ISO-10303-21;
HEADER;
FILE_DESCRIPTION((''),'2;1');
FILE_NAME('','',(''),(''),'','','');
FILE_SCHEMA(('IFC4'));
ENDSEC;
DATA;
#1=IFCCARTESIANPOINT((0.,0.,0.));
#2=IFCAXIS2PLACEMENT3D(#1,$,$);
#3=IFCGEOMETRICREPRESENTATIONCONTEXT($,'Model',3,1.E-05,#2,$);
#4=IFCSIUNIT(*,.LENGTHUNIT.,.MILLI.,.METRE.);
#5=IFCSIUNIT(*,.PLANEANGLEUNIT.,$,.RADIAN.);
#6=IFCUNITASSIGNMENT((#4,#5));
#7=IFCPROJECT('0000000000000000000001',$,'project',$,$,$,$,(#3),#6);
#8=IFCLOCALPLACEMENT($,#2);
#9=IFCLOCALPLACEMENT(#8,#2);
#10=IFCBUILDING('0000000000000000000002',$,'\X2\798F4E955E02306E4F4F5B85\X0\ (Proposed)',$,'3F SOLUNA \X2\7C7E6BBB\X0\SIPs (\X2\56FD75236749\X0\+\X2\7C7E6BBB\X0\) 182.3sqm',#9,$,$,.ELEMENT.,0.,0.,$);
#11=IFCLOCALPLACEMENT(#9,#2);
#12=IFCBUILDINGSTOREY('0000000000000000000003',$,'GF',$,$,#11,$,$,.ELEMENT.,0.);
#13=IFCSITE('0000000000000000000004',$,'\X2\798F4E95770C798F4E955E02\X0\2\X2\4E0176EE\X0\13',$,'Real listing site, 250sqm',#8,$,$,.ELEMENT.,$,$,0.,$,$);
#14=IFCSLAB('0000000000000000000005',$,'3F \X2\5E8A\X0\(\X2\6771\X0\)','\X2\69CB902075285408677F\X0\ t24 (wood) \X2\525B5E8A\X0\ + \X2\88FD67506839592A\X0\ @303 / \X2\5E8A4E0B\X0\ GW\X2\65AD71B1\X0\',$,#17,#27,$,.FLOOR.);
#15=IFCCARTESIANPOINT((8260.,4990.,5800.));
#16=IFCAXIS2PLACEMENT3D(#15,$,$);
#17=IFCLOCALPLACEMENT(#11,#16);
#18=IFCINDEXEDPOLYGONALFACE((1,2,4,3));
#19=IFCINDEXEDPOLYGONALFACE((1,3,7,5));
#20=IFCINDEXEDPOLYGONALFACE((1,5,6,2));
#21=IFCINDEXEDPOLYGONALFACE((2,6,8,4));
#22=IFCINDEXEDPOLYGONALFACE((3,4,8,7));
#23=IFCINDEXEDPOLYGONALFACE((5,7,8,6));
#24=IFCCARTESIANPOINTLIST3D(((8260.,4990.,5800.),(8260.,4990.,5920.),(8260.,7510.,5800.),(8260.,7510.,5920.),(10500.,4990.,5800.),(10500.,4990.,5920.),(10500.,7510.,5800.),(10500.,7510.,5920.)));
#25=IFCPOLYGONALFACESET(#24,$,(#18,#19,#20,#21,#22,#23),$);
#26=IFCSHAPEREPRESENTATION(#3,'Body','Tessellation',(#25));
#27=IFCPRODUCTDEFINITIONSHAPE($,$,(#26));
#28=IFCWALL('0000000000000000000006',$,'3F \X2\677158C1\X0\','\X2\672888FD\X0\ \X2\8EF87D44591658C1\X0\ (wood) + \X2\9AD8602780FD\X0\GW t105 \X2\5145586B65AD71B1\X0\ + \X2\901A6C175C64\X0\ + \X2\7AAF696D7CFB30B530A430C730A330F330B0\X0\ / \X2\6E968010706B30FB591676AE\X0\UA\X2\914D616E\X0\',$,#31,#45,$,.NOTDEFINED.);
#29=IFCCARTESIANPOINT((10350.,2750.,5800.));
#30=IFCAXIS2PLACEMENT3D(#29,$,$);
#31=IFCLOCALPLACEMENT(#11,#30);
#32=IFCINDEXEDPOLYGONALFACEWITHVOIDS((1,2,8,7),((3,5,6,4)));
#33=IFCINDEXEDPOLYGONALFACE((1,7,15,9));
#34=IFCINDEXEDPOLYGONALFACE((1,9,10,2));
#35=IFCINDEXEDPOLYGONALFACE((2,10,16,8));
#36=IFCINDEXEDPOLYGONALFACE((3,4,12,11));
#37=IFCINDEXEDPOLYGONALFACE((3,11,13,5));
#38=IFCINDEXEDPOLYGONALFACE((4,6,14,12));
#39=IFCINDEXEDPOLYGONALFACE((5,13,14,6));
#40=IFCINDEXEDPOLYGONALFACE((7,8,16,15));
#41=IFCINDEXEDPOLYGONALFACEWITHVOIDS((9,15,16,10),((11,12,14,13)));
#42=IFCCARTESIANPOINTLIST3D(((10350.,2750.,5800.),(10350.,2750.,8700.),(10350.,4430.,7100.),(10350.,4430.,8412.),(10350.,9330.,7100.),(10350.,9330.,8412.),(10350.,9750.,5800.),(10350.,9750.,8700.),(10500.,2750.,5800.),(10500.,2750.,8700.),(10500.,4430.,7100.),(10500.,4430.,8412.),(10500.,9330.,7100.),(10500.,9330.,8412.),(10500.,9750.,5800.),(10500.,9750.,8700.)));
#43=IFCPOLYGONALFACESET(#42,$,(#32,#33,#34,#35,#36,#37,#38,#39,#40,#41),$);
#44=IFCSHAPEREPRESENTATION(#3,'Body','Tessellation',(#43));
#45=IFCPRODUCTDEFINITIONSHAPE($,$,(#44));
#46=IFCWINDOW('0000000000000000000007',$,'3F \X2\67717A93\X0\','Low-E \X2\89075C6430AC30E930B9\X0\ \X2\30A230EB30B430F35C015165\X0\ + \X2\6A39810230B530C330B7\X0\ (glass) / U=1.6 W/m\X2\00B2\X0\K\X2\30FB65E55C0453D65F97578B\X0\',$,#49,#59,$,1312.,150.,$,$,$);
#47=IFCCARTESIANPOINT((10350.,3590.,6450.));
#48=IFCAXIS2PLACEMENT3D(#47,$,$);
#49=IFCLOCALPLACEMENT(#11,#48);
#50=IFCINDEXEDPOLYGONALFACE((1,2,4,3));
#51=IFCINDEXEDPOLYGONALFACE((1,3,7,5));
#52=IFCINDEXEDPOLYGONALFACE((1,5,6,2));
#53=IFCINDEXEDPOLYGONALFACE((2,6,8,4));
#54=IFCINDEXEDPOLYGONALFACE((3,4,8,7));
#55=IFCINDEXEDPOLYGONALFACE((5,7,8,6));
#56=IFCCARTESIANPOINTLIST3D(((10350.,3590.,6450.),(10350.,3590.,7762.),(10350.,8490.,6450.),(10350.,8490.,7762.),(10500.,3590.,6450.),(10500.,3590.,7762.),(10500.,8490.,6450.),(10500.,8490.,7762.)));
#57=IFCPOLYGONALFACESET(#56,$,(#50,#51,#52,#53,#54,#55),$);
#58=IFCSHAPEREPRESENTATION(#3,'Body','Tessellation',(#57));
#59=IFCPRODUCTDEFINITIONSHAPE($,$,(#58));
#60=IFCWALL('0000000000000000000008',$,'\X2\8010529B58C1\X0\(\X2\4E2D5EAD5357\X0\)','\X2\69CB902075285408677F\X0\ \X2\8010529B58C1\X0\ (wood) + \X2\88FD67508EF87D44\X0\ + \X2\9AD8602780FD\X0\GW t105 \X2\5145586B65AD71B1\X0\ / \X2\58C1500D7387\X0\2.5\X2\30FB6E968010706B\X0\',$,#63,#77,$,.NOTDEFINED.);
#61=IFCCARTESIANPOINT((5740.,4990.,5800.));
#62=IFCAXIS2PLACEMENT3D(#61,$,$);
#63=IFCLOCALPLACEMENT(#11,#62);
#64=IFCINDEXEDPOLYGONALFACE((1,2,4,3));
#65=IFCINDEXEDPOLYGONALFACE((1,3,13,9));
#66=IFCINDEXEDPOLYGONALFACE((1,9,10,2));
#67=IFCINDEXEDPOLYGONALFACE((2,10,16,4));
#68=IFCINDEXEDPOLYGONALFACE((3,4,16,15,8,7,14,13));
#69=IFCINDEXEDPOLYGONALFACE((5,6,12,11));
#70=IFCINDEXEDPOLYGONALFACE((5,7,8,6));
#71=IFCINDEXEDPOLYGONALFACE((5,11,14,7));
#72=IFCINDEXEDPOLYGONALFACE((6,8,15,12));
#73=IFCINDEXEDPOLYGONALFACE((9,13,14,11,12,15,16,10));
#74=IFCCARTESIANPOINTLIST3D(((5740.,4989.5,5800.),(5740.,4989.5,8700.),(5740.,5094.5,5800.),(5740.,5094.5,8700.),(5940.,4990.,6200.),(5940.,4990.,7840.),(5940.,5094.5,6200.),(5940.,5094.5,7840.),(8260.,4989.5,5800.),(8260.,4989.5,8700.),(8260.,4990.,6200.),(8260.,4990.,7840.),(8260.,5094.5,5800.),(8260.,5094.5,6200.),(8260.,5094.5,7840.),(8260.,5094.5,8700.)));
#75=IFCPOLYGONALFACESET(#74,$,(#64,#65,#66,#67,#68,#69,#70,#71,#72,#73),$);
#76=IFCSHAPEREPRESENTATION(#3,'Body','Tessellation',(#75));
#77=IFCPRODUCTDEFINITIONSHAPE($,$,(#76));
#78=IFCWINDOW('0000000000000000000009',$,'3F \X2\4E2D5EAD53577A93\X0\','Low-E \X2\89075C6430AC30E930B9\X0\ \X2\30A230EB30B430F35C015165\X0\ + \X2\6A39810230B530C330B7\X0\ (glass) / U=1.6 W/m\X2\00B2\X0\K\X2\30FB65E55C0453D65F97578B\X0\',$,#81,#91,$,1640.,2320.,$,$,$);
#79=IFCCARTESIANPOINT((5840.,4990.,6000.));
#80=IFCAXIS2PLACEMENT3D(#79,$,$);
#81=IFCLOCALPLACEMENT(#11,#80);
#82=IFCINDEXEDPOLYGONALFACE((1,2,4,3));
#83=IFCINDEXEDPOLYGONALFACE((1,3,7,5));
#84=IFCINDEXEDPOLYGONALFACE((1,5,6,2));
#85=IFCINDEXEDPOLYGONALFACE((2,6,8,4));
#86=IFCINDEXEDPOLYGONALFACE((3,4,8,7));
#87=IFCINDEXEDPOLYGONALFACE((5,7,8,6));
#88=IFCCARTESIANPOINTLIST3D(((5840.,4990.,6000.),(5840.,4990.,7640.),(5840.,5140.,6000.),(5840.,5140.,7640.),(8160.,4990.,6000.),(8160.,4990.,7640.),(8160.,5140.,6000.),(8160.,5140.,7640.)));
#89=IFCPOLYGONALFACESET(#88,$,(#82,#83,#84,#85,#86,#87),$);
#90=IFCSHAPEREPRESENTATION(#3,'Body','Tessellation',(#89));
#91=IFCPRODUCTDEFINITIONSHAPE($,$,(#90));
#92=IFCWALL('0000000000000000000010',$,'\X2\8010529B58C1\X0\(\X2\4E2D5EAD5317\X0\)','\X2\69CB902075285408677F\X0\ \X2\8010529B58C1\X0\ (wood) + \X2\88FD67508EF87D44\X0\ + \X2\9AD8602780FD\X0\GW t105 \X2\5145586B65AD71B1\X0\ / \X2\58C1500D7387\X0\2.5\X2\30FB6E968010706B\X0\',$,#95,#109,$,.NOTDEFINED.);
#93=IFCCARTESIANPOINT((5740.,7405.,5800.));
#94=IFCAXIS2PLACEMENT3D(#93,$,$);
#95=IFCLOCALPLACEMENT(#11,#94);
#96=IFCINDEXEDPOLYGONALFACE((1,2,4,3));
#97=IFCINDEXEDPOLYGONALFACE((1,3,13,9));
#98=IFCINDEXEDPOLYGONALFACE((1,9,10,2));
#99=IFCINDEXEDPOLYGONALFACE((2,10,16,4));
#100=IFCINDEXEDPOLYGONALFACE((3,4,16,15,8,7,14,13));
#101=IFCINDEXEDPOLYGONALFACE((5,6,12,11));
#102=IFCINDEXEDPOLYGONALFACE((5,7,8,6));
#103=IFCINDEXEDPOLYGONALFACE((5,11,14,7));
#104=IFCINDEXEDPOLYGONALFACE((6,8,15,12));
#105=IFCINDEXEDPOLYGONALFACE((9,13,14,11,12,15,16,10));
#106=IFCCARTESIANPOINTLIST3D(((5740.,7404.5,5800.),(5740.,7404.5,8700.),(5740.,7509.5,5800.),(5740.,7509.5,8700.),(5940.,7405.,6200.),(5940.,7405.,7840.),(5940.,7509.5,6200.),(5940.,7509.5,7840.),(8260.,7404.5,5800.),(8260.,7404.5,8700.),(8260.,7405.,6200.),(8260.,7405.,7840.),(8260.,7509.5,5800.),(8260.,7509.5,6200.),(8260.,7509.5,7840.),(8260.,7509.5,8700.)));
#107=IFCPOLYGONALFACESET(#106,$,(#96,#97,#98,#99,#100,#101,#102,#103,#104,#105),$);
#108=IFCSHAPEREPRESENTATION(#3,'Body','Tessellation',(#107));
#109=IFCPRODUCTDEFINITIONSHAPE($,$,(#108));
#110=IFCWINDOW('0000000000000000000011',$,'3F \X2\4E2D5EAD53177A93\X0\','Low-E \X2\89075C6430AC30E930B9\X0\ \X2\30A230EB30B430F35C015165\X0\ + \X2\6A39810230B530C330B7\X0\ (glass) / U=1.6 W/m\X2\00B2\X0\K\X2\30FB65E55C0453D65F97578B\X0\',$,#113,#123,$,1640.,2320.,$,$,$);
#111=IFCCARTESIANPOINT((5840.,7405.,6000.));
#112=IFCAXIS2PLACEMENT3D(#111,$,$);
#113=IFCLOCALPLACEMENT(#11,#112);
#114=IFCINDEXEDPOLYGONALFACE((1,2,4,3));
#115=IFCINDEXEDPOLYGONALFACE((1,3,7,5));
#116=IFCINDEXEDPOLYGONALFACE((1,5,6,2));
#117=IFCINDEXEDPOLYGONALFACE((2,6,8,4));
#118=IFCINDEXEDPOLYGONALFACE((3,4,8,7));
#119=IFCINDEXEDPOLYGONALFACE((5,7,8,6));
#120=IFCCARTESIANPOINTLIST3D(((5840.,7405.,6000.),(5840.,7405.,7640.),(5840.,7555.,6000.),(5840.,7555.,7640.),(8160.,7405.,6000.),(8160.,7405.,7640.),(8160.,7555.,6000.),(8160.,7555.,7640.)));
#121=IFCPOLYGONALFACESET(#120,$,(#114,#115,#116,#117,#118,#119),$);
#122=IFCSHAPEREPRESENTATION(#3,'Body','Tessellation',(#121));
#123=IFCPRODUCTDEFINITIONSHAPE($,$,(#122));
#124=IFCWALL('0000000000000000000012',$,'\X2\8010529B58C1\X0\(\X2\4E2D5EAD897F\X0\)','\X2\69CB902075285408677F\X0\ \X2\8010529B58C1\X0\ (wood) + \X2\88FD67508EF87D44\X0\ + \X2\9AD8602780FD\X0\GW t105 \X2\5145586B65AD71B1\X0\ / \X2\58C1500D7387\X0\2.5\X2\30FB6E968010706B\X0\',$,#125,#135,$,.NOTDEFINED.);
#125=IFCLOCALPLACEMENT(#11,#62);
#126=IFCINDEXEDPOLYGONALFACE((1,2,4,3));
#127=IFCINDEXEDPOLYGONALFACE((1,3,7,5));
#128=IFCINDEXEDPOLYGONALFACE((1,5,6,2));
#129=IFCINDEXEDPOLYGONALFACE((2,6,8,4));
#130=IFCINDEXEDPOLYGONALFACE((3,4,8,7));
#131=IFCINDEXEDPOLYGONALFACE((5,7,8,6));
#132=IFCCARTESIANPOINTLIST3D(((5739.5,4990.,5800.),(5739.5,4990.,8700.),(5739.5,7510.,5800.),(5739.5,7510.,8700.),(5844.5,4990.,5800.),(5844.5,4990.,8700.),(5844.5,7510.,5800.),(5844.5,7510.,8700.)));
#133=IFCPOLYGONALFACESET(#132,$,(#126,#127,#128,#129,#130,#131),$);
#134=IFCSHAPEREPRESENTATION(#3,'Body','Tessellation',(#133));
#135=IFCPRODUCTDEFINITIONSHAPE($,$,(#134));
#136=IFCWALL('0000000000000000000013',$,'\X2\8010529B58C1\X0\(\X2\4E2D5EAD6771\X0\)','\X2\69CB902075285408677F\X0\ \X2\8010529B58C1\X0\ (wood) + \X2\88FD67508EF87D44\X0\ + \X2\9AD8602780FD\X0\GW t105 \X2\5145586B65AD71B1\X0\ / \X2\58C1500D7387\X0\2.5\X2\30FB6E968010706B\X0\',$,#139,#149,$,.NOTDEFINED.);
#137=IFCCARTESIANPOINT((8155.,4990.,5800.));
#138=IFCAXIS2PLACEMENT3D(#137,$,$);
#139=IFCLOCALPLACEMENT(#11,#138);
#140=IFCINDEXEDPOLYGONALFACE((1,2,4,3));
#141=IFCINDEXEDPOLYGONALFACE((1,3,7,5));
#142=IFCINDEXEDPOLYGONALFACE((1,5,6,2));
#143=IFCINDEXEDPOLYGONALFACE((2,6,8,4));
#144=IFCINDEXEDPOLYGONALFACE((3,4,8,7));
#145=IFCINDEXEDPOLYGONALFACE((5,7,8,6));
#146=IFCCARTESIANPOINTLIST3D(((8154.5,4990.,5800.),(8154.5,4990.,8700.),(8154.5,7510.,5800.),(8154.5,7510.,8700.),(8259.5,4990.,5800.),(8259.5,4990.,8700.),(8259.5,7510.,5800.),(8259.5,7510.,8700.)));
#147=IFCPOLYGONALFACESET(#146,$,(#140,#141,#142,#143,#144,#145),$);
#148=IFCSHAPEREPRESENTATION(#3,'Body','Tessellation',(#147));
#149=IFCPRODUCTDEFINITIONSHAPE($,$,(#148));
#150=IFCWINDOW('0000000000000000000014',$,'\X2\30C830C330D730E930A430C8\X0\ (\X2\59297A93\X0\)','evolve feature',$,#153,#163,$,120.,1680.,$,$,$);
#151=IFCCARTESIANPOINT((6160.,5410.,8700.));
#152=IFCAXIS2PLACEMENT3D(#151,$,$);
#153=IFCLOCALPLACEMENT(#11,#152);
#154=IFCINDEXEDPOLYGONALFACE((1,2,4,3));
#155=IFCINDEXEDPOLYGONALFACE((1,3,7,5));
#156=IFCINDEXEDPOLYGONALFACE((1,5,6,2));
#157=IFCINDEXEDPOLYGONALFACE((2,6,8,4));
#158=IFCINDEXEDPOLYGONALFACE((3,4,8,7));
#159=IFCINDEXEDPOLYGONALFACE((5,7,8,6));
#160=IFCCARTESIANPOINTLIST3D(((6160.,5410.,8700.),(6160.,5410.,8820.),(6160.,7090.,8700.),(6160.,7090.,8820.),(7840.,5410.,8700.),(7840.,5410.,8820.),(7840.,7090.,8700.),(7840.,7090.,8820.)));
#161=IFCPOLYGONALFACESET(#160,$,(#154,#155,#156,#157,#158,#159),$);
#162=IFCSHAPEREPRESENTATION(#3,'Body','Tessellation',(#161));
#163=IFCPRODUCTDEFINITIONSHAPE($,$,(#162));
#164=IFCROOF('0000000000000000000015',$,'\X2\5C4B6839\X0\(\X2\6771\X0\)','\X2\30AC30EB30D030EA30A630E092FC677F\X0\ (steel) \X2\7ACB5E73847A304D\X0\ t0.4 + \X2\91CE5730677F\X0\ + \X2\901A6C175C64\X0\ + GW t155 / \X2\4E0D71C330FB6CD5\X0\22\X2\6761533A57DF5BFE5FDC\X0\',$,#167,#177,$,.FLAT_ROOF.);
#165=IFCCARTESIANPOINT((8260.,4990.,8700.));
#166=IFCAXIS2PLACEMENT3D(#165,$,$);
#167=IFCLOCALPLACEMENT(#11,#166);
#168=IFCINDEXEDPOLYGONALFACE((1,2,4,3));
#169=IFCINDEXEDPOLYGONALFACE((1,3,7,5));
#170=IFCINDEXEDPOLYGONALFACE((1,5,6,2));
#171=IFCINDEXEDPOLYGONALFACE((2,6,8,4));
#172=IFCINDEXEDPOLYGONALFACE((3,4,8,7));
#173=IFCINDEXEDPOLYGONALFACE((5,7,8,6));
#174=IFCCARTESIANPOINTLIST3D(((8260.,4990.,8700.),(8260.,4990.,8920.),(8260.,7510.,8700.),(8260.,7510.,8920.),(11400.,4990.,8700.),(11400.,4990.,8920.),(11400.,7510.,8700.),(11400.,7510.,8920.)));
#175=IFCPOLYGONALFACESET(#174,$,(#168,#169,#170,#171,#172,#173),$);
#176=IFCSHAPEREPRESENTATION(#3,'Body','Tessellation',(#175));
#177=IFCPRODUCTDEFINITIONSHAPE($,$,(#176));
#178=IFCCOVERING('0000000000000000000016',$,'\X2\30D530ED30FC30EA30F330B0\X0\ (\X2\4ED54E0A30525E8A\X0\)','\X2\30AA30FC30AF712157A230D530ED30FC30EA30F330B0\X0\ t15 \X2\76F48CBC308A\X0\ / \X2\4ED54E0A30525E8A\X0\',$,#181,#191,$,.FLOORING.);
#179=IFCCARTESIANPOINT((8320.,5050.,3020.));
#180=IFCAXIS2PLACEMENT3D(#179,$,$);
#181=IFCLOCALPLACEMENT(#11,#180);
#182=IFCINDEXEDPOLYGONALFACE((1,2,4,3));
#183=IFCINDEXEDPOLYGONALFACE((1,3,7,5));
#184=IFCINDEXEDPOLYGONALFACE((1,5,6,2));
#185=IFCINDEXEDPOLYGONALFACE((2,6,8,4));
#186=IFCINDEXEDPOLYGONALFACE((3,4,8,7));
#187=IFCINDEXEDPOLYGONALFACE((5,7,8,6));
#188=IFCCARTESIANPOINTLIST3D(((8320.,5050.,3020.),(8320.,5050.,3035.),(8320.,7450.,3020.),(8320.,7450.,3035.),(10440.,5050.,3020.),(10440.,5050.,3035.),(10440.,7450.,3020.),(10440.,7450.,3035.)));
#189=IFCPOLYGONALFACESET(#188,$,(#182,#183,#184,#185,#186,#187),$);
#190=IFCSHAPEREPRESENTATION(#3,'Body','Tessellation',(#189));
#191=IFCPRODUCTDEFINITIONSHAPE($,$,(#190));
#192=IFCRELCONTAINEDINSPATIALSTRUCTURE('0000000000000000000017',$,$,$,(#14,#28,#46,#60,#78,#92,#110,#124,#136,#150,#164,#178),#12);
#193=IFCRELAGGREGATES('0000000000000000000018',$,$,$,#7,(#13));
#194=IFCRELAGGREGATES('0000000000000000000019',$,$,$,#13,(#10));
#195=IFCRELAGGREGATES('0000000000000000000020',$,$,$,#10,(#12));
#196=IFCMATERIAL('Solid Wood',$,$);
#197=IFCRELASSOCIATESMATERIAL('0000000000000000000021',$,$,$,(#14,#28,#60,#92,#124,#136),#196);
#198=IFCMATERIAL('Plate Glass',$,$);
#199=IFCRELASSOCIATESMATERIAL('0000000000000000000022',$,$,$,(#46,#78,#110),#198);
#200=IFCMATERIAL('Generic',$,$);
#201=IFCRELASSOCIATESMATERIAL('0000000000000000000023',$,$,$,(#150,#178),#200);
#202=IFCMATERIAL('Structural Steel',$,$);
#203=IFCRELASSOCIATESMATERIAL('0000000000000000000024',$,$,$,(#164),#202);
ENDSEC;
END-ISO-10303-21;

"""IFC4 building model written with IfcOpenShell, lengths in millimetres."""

from ifc_helpers import new_model, si_unit, frame, frame_2d, origin, place, context, project, spatial, rectangle, extrude, material, element, fill, save


model = new_model("IFC4")

# Units and contexts
model_context = context("Model", 3, precision=1e-05, world=origin())
ifc_project = project(units=[si_unit("LENGTHUNIT", "METRE", prefix="MILLI"), si_unit("PLANEANGLEUNIT", "RADIAN")], contexts=[model_context])

# Site, building, storey
site_placement = place(None, origin())
site = spatial("IfcSite", under=ifc_project, at=site_placement, Name="福井県福井市2丁目13", ObjectType="Real listing site, 250sqm", CompositionType="ELEMENT", RefElevation=0.0)
building_placement = place(site_placement, origin())
building = spatial("IfcBuilding", under=site, at=building_placement, Name="福井市の住宅 (Proposed)", ObjectType="3F SOLUNA 籾殻SIPs (国産杉+籾殻) 182.3sqm", CompositionType="ELEMENT", ElevationOfRefHeight=0.0, ElevationOfTerrain=0.0)
storey_placement = place(building_placement, origin())
storey = spatial("IfcBuildingStorey", under=building, at=storey_placement, Name="GF", CompositionType="ELEMENT", Elevation=0.0)

# Slab
ifc_material_1 = material(Name="Solid Wood")
slab_placement = place(storey_placement, frame((8260.0, 4990.0, 5800.0)))
element("IfcSlab", 1, at=slab_placement, inside=storey, material=ifc_material_1, Name="3F 床(東)", Description="構造用合板 t24 (wood) 剛床 + 製材根太 @303 / 床下 GW断熱", PredefinedType="FLOOR", context=model_context, shape_type="SweptSolid", body=[
    extrude(rectangle(XDim=2240.0, YDim=2520.0, at=frame_2d((1120.0, 1260.0))), frame((8260.0, 4990.0, 5800.0)), (0.0, 0.0, 1.0), 120.0),
])

# Walls, openings, windows
wall_1_placement = place(storey_placement, frame((10350.0, 2750.0, 5800.0)))
wall_1 = element("IfcWall", 2, at=wall_1_placement, inside=storey, material=ifc_material_1, Name="3F 東壁", Description="木製 軸組外壁 (wood) + 高性能GW t105 充填断熱 + 通気層 + 窯業系サイディング / 準耐火・外皮UA配慮", PredefinedType="NOTDEFINED", context=model_context, shape_type="SweptSolid", body=[
    extrude(rectangle(XDim=150.0, YDim=7000.0, at=frame_2d((75.0, 3500.0))), frame((10350.0, 2750.0, 5800.0)), (0.0, 0.0, 1.0), 2900.0),
])
opening_1_placement = place(storey_placement, frame((10350.0, 3590.0, 6450.0)))
opening_1 = element("IfcOpeningElement", 3, at=opening_1_placement, cuts=wall_1, PredefinedType="NOTDEFINED", context=model_context, shape_type="SweptSolid", body=[
    extrude(rectangle(XDim=150.0, YDim=4900.0, at=frame_2d((75.0, 2450.0))), frame((10350.0, 3590.0, 6450.0)), (0.0, 0.0, 1.0), 1312.0),
])
ifc_material_2 = material(Name="Plate Glass")
window_1_placement = place(storey_placement, frame((10350.0, 3590.0, 6450.0)))
window_1 = element("IfcWindow", 4, at=window_1_placement, inside=storey, material=ifc_material_2, Name="3F 東窓", Description="Low-E 複層ガラス アルゴン封入 + 樹脂サッシ (glass) / U=1.6 W/m²K・日射取得型", OverallHeight=1312.0, OverallWidth=150.0, context=model_context, shape_type="SweptSolid", body=[
    extrude(rectangle(XDim=150.0, YDim=4900.0, at=frame_2d((75.0, 2450.0))), frame((10350.0, 3590.0, 6450.0)), (0.0, 0.0, 1.0), 1312.0),
])
fill(opening_1, window_1)
wall_2_placement = place(storey_placement, frame((5740.0, 4990.0, 5800.0)))
wall_2 = element("IfcWall", 5, at=wall_2_placement, inside=storey, material=ifc_material_1, Name="耐力壁(中庭南)", Description="構造用合板 耐力壁 (wood) + 製材軸組 + 高性能GW t105 充填断熱 / 壁倍率2.5・準耐火", PredefinedType="NOTDEFINED", context=model_context, shape_type="SweptSolid", body=[
    extrude(rectangle(XDim=2520.0, YDim=105.0, at=frame_2d((1260.0, 52.0))), frame((5740.0, 4990.0, 5800.0)), (0.0, 0.0, 1.0), 2900.0),
])
opening_2_placement = place(storey_placement, frame((5840.0, 4990.0, 6000.0)))
opening_2 = element("IfcOpeningElement", 6, at=opening_2_placement, cuts=wall_2, PredefinedType="NOTDEFINED", context=model_context, shape_type="SweptSolid", body=[
    extrude(rectangle(XDim=2320.0, YDim=150.0, at=frame_2d((1160.0, 75.0))), frame((5840.0, 4990.0, 6000.0)), (0.0, 0.0, 1.0), 1640.0),
])
window_2_placement = place(storey_placement, frame((5840.0, 4990.0, 6000.0)))
window_2 = element("IfcWindow", 7, at=window_2_placement, inside=storey, material=ifc_material_2, Name="3F 中庭南窓", Description="Low-E 複層ガラス アルゴン封入 + 樹脂サッシ (glass) / U=1.6 W/m²K・日射取得型", OverallHeight=1640.0, OverallWidth=2320.0, context=model_context, shape_type="SweptSolid", body=[
    extrude(rectangle(XDim=2320.0, YDim=150.0, at=frame_2d((1160.0, 75.0))), frame((5840.0, 4990.0, 6000.0)), (0.0, 0.0, 1.0), 1640.0),
])
fill(opening_2, window_2)
wall_3_placement = place(storey_placement, frame((5740.0, 7405.0, 5800.0)))
wall_3 = element("IfcWall", 8, at=wall_3_placement, inside=storey, material=ifc_material_1, Name="耐力壁(中庭北)", Description="構造用合板 耐力壁 (wood) + 製材軸組 + 高性能GW t105 充填断熱 / 壁倍率2.5・準耐火", PredefinedType="NOTDEFINED", context=model_context, shape_type="SweptSolid", body=[
    extrude(rectangle(XDim=2520.0, YDim=105.0, at=frame_2d((1260.0, 52.0))), frame((5740.0, 7405.0, 5800.0)), (0.0, 0.0, 1.0), 2900.0),
])
opening_3_placement = place(storey_placement, frame((5840.0, 7405.0, 6000.0)))
opening_3 = element("IfcOpeningElement", 9, at=opening_3_placement, cuts=wall_3, PredefinedType="NOTDEFINED", context=model_context, shape_type="SweptSolid", body=[
    extrude(rectangle(XDim=2320.0, YDim=150.0, at=frame_2d((1160.0, 75.0))), frame((5840.0, 7405.0, 6000.0)), (0.0, 0.0, 1.0), 1640.0),
])
window_3_placement = place(storey_placement, frame((5840.0, 7405.0, 6000.0)))
window_3 = element("IfcWindow", 10, at=window_3_placement, inside=storey, material=ifc_material_2, Name="3F 中庭北窓", Description="Low-E 複層ガラス アルゴン封入 + 樹脂サッシ (glass) / U=1.6 W/m²K・日射取得型", OverallHeight=1640.0, OverallWidth=2320.0, context=model_context, shape_type="SweptSolid", body=[
    extrude(rectangle(XDim=2320.0, YDim=150.0, at=frame_2d((1160.0, 75.0))), frame((5840.0, 7405.0, 6000.0)), (0.0, 0.0, 1.0), 1640.0),
])
fill(opening_3, window_3)

# Walls
wall_4_placement = place(storey_placement, frame((5740.0, 4990.0, 5800.0)))
element("IfcWall", 11, at=wall_4_placement, inside=storey, material=ifc_material_1, Name="耐力壁(中庭西)", Description="構造用合板 耐力壁 (wood) + 製材軸組 + 高性能GW t105 充填断熱 / 壁倍率2.5・準耐火", PredefinedType="NOTDEFINED", context=model_context, shape_type="SweptSolid", body=[
    extrude(rectangle(XDim=105.0, YDim=2520.0, at=frame_2d((52.0, 1260.0))), frame((5740.0, 4990.0, 5800.0)), (0.0, 0.0, 1.0), 2900.0),
])
wall_5_placement = place(storey_placement, frame((8155.0, 4990.0, 5800.0)))
element("IfcWall", 12, at=wall_5_placement, inside=storey, material=ifc_material_1, Name="耐力壁(中庭東)", Description="構造用合板 耐力壁 (wood) + 製材軸組 + 高性能GW t105 充填断熱 / 壁倍率2.5・準耐火", PredefinedType="NOTDEFINED", context=model_context, shape_type="SweptSolid", body=[
    extrude(rectangle(XDim=105.0, YDim=2520.0, at=frame_2d((52.0, 1260.0))), frame((8155.0, 4990.0, 5800.0)), (0.0, 0.0, 1.0), 2900.0),
])

# Window
ifc_material_3 = material(Name="Generic")
window_4_placement = place(storey_placement, frame((6160.0, 5410.0, 8700.0)))
element("IfcWindow", 13, at=window_4_placement, inside=storey, material=ifc_material_3, Name="トップライト (天窓)", Description="evolve feature", OverallHeight=120.0, OverallWidth=1680.0, context=model_context, shape_type="SweptSolid", body=[
    extrude(rectangle(XDim=1680.0, YDim=1680.0, at=frame_2d((840.0, 840.0))), frame((6160.0, 5410.0, 8700.0)), (0.0, 0.0, 1.0), 120.0),
])

# Roof
ifc_material_4 = material(Name="Structural Steel")
for number, where, name in (
    (14, (8260.0, 4990.0, 8700.0), "屋根(東)"),
):
    element("IfcRoof", number, at=place(storey_placement, frame(where)), inside=storey, material=ifc_material_4, Name=name, Description="ガルバリウム鋼板 (steel) 立平葺き t0.4 + 野地板 + 通気層 + GW t155 / 不燃・法22条区域対応", PredefinedType="FLAT_ROOF", context=model_context, shape_type="SweptSolid", body=[
        extrude(rectangle(XDim=3140.0, YDim=2520.0, at=frame_2d((1570.0, 1260.0))), frame((8260.0, 4990.0, 8700.0)), (0.0, 0.0, 1.0), 220.0),
    ])

# Covering
covering_1_placement = place(storey_placement, frame((8320.0, 5050.0, 3020.0)))
element("IfcCovering", 15, at=covering_1_placement, inside=storey, material=ifc_material_3, Name="フローリング (仕上げ床)", Description="オーク無垢フローリング t15 直貼り / 仕上げ床", PredefinedType="FLOORING", context=model_context, shape_type="SweptSolid", body=[
    extrude(rectangle(XDim=2120.0, YDim=2400.0, at=frame_2d((1060.0, 1200.0))), frame((8320.0, 5050.0, 3020.0)), (0.0, 0.0, 1.0), 15.0),
])

save(model, "model.ifc")
